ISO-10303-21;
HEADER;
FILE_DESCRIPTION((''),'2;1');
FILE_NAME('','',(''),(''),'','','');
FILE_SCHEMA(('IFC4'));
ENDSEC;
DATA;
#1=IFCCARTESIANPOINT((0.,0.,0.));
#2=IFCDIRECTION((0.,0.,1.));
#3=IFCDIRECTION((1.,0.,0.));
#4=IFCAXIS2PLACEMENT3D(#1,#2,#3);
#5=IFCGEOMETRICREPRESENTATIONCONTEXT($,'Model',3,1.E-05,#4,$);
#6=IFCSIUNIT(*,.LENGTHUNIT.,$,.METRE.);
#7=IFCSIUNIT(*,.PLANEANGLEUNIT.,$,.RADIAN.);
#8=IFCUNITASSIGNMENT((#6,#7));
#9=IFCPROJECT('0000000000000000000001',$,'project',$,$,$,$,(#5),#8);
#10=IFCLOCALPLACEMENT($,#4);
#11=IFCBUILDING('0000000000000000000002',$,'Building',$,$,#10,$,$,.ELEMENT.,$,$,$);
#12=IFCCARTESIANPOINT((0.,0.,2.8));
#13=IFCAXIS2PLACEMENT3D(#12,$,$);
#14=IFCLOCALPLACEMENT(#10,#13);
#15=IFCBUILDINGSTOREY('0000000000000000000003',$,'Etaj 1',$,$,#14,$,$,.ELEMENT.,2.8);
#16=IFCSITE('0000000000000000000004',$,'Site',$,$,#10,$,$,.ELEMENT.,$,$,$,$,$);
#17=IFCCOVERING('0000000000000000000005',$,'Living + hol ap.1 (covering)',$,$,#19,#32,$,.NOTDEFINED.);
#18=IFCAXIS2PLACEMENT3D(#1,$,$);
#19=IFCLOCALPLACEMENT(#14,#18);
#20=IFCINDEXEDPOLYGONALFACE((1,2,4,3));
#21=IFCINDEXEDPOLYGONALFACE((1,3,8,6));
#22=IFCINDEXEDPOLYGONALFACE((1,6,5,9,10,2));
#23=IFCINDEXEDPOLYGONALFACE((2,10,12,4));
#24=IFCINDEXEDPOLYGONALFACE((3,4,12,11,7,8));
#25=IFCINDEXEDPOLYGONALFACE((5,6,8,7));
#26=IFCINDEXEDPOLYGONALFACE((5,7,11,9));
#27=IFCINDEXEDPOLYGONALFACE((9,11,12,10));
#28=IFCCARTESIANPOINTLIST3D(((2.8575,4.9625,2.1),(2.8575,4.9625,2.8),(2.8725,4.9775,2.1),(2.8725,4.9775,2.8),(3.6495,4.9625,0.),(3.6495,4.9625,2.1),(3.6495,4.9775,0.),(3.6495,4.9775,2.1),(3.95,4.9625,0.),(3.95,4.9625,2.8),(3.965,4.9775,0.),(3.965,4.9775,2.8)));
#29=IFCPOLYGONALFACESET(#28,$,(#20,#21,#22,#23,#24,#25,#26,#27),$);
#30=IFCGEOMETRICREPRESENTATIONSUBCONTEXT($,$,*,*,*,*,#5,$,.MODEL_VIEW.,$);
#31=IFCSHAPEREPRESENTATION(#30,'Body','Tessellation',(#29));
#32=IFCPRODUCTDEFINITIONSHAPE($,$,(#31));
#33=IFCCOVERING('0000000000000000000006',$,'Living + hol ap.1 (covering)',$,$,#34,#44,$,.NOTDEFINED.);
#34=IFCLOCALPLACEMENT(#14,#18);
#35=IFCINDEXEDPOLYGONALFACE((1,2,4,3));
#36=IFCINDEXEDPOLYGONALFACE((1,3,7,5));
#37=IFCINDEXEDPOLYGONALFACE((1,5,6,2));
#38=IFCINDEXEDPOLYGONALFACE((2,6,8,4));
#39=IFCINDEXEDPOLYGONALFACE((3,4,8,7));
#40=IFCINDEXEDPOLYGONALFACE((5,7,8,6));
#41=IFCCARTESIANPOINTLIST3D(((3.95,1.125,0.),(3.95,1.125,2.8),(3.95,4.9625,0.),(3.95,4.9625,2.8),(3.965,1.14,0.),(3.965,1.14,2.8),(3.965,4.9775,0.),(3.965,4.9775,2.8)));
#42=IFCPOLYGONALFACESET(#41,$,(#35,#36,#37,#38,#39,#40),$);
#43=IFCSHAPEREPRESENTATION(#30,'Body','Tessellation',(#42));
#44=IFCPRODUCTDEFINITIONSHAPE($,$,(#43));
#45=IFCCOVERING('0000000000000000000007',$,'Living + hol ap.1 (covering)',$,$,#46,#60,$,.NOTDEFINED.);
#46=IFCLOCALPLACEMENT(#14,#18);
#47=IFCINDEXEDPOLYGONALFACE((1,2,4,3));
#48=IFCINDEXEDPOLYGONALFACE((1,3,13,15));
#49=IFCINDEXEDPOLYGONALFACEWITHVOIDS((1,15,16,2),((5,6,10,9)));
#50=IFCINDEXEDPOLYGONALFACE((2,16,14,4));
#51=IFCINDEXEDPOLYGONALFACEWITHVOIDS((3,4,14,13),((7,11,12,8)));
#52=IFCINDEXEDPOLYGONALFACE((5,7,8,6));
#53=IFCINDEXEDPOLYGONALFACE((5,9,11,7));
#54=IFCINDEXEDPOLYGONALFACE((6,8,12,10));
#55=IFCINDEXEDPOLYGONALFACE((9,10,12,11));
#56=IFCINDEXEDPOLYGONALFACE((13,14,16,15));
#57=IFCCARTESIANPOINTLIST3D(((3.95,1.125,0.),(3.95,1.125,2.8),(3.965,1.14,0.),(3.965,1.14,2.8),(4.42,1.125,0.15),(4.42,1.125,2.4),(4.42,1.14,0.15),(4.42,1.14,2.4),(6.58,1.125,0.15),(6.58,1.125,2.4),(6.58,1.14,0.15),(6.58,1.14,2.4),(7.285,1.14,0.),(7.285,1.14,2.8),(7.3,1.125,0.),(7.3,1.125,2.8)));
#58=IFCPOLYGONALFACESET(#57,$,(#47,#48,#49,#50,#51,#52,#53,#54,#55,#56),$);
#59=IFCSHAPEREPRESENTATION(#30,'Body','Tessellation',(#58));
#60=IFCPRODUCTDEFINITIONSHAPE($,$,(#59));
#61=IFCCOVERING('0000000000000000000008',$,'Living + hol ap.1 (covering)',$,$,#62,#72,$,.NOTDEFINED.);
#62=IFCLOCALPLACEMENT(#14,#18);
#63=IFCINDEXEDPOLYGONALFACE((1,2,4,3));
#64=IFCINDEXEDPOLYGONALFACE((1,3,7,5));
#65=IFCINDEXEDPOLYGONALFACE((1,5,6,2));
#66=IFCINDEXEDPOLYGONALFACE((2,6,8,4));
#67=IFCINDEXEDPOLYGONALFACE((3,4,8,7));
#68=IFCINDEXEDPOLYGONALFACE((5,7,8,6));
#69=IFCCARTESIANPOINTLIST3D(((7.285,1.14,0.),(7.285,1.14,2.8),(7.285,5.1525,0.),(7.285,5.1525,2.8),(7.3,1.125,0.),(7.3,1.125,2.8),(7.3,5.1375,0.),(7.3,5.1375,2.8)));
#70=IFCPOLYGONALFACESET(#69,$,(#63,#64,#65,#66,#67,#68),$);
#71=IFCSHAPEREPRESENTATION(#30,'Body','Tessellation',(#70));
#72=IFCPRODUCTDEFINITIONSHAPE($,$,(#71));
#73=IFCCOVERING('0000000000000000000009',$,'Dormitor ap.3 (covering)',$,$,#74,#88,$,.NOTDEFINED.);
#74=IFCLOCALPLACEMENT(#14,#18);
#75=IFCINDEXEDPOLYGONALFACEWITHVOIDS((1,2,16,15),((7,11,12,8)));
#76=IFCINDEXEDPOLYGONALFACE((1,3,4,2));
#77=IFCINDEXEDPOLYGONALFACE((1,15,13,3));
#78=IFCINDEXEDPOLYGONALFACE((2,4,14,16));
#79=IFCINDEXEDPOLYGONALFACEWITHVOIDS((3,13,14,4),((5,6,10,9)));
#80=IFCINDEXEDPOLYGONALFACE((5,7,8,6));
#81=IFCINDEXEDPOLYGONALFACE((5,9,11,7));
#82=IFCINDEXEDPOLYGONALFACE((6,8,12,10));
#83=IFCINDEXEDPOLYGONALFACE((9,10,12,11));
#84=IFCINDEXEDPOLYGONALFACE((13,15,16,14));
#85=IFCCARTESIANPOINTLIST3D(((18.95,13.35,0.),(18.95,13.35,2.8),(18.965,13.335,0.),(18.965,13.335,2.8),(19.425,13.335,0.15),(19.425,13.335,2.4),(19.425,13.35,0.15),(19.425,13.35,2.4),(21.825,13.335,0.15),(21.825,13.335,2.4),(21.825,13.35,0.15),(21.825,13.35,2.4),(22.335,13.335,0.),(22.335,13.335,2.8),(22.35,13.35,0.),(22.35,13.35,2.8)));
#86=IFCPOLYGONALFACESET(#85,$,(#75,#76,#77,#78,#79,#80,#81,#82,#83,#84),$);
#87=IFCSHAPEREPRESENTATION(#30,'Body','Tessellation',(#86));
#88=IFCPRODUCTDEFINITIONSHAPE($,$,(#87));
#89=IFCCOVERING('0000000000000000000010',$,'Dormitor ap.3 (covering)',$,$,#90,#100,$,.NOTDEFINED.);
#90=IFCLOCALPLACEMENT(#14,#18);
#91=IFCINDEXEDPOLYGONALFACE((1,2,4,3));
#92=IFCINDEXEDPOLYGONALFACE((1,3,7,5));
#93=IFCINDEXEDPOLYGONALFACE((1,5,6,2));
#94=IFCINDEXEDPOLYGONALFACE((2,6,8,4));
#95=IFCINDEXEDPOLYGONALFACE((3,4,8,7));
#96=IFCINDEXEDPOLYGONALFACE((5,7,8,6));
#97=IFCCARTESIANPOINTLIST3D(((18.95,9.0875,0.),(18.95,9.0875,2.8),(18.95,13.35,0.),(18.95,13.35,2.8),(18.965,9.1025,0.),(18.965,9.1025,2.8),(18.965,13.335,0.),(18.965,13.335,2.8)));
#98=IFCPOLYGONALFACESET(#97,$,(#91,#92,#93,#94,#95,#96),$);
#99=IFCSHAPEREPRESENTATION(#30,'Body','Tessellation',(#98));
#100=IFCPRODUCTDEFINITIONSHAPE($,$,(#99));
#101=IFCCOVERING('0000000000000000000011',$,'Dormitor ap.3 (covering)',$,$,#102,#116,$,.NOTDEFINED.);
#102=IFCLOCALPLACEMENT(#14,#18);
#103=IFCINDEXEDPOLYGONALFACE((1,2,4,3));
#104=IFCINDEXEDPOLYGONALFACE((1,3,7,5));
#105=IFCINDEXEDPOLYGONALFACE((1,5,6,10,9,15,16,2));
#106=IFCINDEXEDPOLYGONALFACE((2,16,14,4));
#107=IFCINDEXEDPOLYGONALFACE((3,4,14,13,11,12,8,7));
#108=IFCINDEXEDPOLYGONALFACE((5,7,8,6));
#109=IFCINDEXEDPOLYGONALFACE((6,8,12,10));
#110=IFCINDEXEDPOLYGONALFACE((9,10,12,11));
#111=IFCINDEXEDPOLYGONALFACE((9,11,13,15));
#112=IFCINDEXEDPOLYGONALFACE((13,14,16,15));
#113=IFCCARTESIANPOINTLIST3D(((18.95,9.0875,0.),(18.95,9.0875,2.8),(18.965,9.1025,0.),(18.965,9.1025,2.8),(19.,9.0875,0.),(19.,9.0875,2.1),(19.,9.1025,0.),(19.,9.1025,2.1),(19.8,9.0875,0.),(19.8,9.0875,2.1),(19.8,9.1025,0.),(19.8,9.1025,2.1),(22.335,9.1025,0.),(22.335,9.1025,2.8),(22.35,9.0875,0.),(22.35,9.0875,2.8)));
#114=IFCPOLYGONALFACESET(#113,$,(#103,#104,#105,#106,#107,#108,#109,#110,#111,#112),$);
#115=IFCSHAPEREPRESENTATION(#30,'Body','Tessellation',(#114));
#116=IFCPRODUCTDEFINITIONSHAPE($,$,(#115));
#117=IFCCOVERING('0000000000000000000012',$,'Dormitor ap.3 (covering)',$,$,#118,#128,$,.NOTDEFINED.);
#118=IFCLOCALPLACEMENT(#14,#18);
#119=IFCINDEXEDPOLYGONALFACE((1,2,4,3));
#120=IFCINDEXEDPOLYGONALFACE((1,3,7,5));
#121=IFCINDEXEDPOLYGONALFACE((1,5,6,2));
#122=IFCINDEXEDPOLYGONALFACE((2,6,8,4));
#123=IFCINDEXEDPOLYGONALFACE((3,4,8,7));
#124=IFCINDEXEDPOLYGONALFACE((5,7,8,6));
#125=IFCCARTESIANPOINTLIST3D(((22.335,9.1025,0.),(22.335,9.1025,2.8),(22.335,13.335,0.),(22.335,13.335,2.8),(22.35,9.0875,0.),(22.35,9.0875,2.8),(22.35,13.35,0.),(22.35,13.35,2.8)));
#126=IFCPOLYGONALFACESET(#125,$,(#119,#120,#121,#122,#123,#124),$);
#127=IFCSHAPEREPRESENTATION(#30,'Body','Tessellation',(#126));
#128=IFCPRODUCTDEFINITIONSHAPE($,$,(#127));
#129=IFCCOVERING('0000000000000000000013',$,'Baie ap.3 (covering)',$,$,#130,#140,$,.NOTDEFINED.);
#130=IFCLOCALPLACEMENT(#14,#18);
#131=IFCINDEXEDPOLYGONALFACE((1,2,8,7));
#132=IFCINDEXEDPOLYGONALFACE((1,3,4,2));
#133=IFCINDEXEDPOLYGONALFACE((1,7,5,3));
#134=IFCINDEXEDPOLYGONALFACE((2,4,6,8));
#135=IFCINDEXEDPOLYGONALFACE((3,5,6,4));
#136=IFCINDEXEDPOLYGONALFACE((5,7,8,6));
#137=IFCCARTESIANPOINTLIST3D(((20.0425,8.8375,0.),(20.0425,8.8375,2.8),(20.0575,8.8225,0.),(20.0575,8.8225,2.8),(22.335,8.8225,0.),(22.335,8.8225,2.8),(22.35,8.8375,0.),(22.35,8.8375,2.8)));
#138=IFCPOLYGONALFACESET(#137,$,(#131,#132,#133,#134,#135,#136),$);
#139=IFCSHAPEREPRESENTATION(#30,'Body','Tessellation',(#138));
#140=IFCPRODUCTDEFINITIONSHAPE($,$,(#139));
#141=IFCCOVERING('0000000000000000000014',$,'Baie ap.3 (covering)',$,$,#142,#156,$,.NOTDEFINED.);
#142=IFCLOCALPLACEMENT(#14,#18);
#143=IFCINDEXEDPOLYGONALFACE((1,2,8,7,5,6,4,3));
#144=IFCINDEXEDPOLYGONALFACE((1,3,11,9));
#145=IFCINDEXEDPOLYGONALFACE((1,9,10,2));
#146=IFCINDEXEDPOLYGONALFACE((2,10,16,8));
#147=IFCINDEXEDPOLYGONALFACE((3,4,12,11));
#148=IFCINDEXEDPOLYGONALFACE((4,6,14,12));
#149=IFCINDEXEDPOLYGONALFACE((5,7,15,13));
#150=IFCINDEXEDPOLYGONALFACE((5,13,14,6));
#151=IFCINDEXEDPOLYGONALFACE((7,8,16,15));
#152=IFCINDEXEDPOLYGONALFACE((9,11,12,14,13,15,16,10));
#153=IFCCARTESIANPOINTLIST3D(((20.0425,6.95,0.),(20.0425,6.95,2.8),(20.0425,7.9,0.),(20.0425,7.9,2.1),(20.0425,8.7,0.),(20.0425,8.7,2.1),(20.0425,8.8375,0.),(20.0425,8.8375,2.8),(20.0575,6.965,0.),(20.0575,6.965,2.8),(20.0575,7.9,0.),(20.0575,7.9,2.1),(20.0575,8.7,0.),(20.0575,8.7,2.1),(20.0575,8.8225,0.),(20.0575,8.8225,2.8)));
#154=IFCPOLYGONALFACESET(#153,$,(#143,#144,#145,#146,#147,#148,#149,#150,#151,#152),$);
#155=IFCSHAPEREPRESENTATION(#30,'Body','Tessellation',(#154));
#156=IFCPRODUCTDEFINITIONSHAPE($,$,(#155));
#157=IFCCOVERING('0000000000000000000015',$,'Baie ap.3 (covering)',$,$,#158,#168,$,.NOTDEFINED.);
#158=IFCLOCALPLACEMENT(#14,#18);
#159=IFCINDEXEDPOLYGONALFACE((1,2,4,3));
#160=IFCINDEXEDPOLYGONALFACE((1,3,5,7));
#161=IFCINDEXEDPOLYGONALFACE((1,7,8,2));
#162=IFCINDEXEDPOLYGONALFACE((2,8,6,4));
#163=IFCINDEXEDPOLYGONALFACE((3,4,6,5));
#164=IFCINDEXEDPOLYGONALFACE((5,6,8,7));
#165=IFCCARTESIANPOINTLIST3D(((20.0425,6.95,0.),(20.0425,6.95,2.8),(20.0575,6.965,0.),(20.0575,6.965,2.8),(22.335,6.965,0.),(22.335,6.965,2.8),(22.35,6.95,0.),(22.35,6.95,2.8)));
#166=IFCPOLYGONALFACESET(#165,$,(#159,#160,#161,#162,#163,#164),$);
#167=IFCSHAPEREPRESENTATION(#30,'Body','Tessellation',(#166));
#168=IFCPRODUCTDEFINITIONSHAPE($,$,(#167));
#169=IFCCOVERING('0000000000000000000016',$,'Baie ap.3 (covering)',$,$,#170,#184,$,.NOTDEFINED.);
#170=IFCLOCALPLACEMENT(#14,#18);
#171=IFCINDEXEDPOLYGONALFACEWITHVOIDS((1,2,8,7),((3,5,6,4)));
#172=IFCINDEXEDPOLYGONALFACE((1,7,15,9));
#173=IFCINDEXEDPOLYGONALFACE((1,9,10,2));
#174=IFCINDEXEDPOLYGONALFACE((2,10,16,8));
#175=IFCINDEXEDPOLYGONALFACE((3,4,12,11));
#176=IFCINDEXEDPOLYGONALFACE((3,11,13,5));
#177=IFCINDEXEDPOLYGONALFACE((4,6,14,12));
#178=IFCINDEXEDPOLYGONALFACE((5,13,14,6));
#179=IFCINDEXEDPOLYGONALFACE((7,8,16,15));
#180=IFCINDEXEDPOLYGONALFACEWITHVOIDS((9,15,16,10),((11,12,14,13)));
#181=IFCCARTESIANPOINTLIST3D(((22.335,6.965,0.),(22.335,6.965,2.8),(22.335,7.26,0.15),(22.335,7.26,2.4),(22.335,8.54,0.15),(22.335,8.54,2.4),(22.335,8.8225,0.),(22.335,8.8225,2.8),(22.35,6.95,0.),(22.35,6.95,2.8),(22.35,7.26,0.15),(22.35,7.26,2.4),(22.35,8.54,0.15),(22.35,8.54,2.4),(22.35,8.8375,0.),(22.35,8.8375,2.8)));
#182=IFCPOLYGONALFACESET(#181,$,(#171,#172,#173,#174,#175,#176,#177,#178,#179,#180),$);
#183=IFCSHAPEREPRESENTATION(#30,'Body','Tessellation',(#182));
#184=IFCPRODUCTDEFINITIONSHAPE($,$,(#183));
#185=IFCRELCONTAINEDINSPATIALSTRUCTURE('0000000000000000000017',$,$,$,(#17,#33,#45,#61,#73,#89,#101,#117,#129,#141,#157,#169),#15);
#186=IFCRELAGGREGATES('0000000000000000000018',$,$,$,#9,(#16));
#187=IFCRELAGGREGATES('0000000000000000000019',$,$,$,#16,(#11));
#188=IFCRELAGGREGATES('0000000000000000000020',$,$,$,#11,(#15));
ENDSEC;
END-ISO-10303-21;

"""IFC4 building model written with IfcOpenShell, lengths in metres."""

from ifc_helpers import new_model, si_unit, frame, origin, origin_with_axes, origin_2d, place, context, subcontext, project, spatial, polyline, rectangle, outline, extrude, element, save


model = new_model("IFC4")

# Units and contexts
model_context = context("Model", 3, precision=1e-05, world=origin_with_axes())
sub_context = subcontext(model_context, None, None, "MODEL_VIEW")
ifc_project = project(units=[si_unit("LENGTHUNIT", "METRE"), si_unit("PLANEANGLEUNIT", "RADIAN")], contexts=[model_context])

# Site, building, storey
placement = place(None, origin_with_axes())
site = spatial("IfcSite", under=ifc_project, at=placement, Name="Site", CompositionType="ELEMENT")
building = spatial("IfcBuilding", under=site, at=placement, Name="Building", CompositionType="ELEMENT")
storey_placement = place(placement, frame((0.0, 0.0, 2.8)))
storey = spatial("IfcBuildingStorey", under=building, at=storey_placement, Name="Etaj 1", CompositionType="ELEMENT", Elevation=2.8)

# Covering, opening
covering_1_placement = place(storey_placement, origin_with_axes())
covering_1 = element("IfcCovering", 1, at=covering_1_placement, inside=storey, Name="Living + hol ap.1 (covering)", PredefinedType="NOTDEFINED", context=sub_context, shape_type="SweptSolid", body=[
    extrude(outline(polyline([(2.8575, 4.9625), (3.95, 4.9625), (3.965, 4.9775), (2.8725, 4.9775), (2.8575, 4.9625)])), origin(), (0.0, 0.0, 1.0), 2.8),
])
opening_1_placement = place(covering_1_placement, frame((3.2495, 5.0275, 0.0), z_axis=(0.0, -1.0, 0.0), x_axis=(1.0, 0.0, 0.0)))
element("IfcOpeningElement", 2, at=opening_1_placement, cuts=covering_1, PredefinedType="OPENING", context=sub_context, shape_type="SweptSolid", body=[
    extrude(rectangle(XDim=0.8, YDim=2.1, at=origin_2d()), frame((0.0, 1.05, 0.0)), (0.0, 0.0, 1.0), 0.38),
])

# Covering
covering_2_placement = place(storey_placement, origin_with_axes())
element("IfcCovering", 3, at=covering_2_placement, inside=storey, Name="Living + hol ap.1 (covering)", PredefinedType="NOTDEFINED", context=sub_context, shape_type="SweptSolid", body=[
    extrude(outline(polyline([(3.95, 4.9625), (3.95, 1.125), (3.965, 1.14), (3.965, 4.9775), (3.95, 4.9625)])), origin(), (0.0, 0.0, 1.0), 2.8),
])

# Covering, opening
covering_3_placement = place(storey_placement, origin_with_axes())
covering_3 = element("IfcCovering", 4, at=covering_3_placement, inside=storey, Name="Living + hol ap.1 (covering)", PredefinedType="NOTDEFINED", context=sub_context, shape_type="SweptSolid", body=[
    extrude(outline(polyline([(3.95, 1.125), (7.3, 1.125), (7.285, 1.14), (3.965, 1.14), (3.95, 1.125)])), origin(), (0.0, 0.0, 1.0), 2.8),
])
opening_2_placement = place(covering_3_placement, frame((5.5, 1.19, 0.15), z_axis=(0.0, -1.0, 0.0), x_axis=(1.0, 0.0, 0.0)))
element("IfcOpeningElement", 5, at=opening_2_placement, cuts=covering_3, PredefinedType="OPENING", context=sub_context, shape_type="SweptSolid", body=[
    extrude(rectangle(XDim=2.16, YDim=2.25, at=origin_2d()), frame((0.0, 1.125, 0.0)), (0.0, 0.0, 1.0), 0.38),
])

# Covering
covering_4_placement = place(storey_placement, origin_with_axes())
element("IfcCovering", 6, at=covering_4_placement, inside=storey, Name="Living + hol ap.1 (covering)", PredefinedType="NOTDEFINED", context=sub_context, shape_type="SweptSolid", body=[
    extrude(outline(polyline([(7.3, 1.125), (7.3, 5.1375), (7.285, 5.1525), (7.285, 1.14), (7.3, 1.125)])), origin(), (0.0, 0.0, 1.0), 2.8),
])

# Covering, opening
covering_5_placement = place(storey_placement, origin_with_axes())
covering_5 = element("IfcCovering", 7, at=covering_5_placement, inside=storey, Name="Dormitor ap.3 (covering)", PredefinedType="NOTDEFINED", context=sub_context, shape_type="SweptSolid", body=[
    extrude(outline(polyline([(22.35, 13.35), (18.95, 13.35), (18.965, 13.335), (22.335, 13.335), (22.35, 13.35)])), origin(), (0.0, 0.0, 1.0), 2.8),
])
opening_3_placement = place(covering_5_placement, frame((20.625, 13.665, 0.15), z_axis=(0.0, -1.0, 0.0), x_axis=(1.0, 0.0, 0.0)))
element("IfcOpeningElement", 8, at=opening_3_placement, cuts=covering_5, PredefinedType="OPENING", context=sub_context, shape_type="SweptSolid", body=[
    extrude(rectangle(XDim=2.4, YDim=2.25, at=origin_2d()), frame((0.0, 1.125, 0.0)), (0.0, 0.0, 1.0), 0.38),
])

# Covering
covering_6_placement = place(storey_placement, origin_with_axes())
element("IfcCovering", 9, at=covering_6_placement, inside=storey, Name="Dormitor ap.3 (covering)", PredefinedType="NOTDEFINED", context=sub_context, shape_type="SweptSolid", body=[
    extrude(outline(polyline([(18.95, 13.35), (18.95, 9.0875), (18.965, 9.1025), (18.965, 13.335), (18.95, 13.35)])), origin(), (0.0, 0.0, 1.0), 2.8),
])

# Covering, opening
covering_7_placement = place(storey_placement, origin_with_axes())
covering_7 = element("IfcCovering", 10, at=covering_7_placement, inside=storey, Name="Dormitor ap.3 (covering)", PredefinedType="NOTDEFINED", context=sub_context, shape_type="SweptSolid", body=[
    extrude(outline(polyline([(18.95, 9.0875), (22.35, 9.0875), (22.335, 9.1025), (18.965, 9.1025), (18.95, 9.0875)])), origin(), (0.0, 0.0, 1.0), 2.8),
])
opening_4_placement = place(covering_7_placement, frame((19.4, 9.1525, 0.0), z_axis=(0.0, -1.0, 0.0), x_axis=(1.0, 0.0, 0.0)))
element("IfcOpeningElement", 11, at=opening_4_placement, cuts=covering_7, PredefinedType="OPENING", context=sub_context, shape_type="SweptSolid", body=[
    extrude(rectangle(XDim=0.8, YDim=2.1, at=origin_2d()), frame((0.0, 1.05, 0.0)), (0.0, 0.0, 1.0), 0.38),
])

# Coverings
covering_8_placement = place(storey_placement, origin_with_axes())
element("IfcCovering", 12, at=covering_8_placement, inside=storey, Name="Dormitor ap.3 (covering)", PredefinedType="NOTDEFINED", context=sub_context, shape_type="SweptSolid", body=[
    extrude(outline(polyline([(22.35, 9.0875), (22.35, 13.35), (22.335, 13.335), (22.335, 9.1025), (22.35, 9.0875)])), origin(), (0.0, 0.0, 1.0), 2.8),
])
covering_9_placement = place(storey_placement, origin_with_axes())
element("IfcCovering", 13, at=covering_9_placement, inside=storey, Name="Baie ap.3 (covering)", PredefinedType="NOTDEFINED", context=sub_context, shape_type="SweptSolid", body=[
    extrude(outline(polyline([(22.35, 8.8375), (20.0425, 8.8375), (20.0575, 8.8225), (22.335, 8.8225), (22.35, 8.8375)])), origin(), (0.0, 0.0, 1.0), 2.8),
])

# Covering, opening
covering_10_placement = place(storey_placement, origin_with_axes())
covering_10 = element("IfcCovering", 14, at=covering_10_placement, inside=storey, Name="Baie ap.3 (covering)", PredefinedType="NOTDEFINED", context=sub_context, shape_type="SweptSolid", body=[
    extrude(outline(polyline([(20.0425, 8.8375), (20.0425, 6.95), (20.0575, 6.965), (20.0575, 8.8225), (20.0425, 8.8375)])), origin(), (0.0, 0.0, 1.0), 2.8),
])
opening_5_placement = place(covering_10_placement, frame((19.7275, 8.3, 0.0), z_axis=(1.0, 0.0, 0.0), x_axis=(0.0, 1.0, 0.0)))
element("IfcOpeningElement", 15, at=opening_5_placement, cuts=covering_10, PredefinedType="OPENING", context=sub_context, shape_type="SweptSolid", body=[
    extrude(rectangle(XDim=0.8, YDim=2.1, at=origin_2d()), frame((0.0, 1.05, 0.0)), (0.0, 0.0, 1.0), 0.38),
])

# Covering
covering_11_placement = place(storey_placement, origin_with_axes())
element("IfcCovering", 16, at=covering_11_placement, inside=storey, Name="Baie ap.3 (covering)", PredefinedType="NOTDEFINED", context=sub_context, shape_type="SweptSolid", body=[
    extrude(outline(polyline([(20.0425, 6.95), (22.35, 6.95), (22.335, 6.965), (20.0575, 6.965), (20.0425, 6.95)])), origin(), (0.0, 0.0, 1.0), 2.8),
])

# Covering, opening
covering_12_placement = place(storey_placement, origin_with_axes())
covering_12 = element("IfcCovering", 17, at=covering_12_placement, inside=storey, Name="Baie ap.3 (covering)", PredefinedType="NOTDEFINED", context=sub_context, shape_type="SweptSolid", body=[
    extrude(outline(polyline([(22.35, 6.95), (22.35, 8.8375), (22.335, 8.8225), (22.335, 6.965), (22.35, 6.95)])), origin(), (0.0, 0.0, 1.0), 2.8),
])
opening_6_placement = place(covering_12_placement, frame((22.285, 7.9, 0.15), z_axis=(1.0, 0.0, 0.0), x_axis=(0.0, 1.0, 0.0)))
element("IfcOpeningElement", 18, at=opening_6_placement, cuts=covering_12, PredefinedType="OPENING", context=sub_context, shape_type="SweptSolid", body=[
    extrude(rectangle(XDim=1.28, YDim=2.25, at=origin_2d()), frame((0.0, 1.125, 0.0)), (0.0, 0.0, 1.0), 0.38),
])

save(model, "model.ifc")
